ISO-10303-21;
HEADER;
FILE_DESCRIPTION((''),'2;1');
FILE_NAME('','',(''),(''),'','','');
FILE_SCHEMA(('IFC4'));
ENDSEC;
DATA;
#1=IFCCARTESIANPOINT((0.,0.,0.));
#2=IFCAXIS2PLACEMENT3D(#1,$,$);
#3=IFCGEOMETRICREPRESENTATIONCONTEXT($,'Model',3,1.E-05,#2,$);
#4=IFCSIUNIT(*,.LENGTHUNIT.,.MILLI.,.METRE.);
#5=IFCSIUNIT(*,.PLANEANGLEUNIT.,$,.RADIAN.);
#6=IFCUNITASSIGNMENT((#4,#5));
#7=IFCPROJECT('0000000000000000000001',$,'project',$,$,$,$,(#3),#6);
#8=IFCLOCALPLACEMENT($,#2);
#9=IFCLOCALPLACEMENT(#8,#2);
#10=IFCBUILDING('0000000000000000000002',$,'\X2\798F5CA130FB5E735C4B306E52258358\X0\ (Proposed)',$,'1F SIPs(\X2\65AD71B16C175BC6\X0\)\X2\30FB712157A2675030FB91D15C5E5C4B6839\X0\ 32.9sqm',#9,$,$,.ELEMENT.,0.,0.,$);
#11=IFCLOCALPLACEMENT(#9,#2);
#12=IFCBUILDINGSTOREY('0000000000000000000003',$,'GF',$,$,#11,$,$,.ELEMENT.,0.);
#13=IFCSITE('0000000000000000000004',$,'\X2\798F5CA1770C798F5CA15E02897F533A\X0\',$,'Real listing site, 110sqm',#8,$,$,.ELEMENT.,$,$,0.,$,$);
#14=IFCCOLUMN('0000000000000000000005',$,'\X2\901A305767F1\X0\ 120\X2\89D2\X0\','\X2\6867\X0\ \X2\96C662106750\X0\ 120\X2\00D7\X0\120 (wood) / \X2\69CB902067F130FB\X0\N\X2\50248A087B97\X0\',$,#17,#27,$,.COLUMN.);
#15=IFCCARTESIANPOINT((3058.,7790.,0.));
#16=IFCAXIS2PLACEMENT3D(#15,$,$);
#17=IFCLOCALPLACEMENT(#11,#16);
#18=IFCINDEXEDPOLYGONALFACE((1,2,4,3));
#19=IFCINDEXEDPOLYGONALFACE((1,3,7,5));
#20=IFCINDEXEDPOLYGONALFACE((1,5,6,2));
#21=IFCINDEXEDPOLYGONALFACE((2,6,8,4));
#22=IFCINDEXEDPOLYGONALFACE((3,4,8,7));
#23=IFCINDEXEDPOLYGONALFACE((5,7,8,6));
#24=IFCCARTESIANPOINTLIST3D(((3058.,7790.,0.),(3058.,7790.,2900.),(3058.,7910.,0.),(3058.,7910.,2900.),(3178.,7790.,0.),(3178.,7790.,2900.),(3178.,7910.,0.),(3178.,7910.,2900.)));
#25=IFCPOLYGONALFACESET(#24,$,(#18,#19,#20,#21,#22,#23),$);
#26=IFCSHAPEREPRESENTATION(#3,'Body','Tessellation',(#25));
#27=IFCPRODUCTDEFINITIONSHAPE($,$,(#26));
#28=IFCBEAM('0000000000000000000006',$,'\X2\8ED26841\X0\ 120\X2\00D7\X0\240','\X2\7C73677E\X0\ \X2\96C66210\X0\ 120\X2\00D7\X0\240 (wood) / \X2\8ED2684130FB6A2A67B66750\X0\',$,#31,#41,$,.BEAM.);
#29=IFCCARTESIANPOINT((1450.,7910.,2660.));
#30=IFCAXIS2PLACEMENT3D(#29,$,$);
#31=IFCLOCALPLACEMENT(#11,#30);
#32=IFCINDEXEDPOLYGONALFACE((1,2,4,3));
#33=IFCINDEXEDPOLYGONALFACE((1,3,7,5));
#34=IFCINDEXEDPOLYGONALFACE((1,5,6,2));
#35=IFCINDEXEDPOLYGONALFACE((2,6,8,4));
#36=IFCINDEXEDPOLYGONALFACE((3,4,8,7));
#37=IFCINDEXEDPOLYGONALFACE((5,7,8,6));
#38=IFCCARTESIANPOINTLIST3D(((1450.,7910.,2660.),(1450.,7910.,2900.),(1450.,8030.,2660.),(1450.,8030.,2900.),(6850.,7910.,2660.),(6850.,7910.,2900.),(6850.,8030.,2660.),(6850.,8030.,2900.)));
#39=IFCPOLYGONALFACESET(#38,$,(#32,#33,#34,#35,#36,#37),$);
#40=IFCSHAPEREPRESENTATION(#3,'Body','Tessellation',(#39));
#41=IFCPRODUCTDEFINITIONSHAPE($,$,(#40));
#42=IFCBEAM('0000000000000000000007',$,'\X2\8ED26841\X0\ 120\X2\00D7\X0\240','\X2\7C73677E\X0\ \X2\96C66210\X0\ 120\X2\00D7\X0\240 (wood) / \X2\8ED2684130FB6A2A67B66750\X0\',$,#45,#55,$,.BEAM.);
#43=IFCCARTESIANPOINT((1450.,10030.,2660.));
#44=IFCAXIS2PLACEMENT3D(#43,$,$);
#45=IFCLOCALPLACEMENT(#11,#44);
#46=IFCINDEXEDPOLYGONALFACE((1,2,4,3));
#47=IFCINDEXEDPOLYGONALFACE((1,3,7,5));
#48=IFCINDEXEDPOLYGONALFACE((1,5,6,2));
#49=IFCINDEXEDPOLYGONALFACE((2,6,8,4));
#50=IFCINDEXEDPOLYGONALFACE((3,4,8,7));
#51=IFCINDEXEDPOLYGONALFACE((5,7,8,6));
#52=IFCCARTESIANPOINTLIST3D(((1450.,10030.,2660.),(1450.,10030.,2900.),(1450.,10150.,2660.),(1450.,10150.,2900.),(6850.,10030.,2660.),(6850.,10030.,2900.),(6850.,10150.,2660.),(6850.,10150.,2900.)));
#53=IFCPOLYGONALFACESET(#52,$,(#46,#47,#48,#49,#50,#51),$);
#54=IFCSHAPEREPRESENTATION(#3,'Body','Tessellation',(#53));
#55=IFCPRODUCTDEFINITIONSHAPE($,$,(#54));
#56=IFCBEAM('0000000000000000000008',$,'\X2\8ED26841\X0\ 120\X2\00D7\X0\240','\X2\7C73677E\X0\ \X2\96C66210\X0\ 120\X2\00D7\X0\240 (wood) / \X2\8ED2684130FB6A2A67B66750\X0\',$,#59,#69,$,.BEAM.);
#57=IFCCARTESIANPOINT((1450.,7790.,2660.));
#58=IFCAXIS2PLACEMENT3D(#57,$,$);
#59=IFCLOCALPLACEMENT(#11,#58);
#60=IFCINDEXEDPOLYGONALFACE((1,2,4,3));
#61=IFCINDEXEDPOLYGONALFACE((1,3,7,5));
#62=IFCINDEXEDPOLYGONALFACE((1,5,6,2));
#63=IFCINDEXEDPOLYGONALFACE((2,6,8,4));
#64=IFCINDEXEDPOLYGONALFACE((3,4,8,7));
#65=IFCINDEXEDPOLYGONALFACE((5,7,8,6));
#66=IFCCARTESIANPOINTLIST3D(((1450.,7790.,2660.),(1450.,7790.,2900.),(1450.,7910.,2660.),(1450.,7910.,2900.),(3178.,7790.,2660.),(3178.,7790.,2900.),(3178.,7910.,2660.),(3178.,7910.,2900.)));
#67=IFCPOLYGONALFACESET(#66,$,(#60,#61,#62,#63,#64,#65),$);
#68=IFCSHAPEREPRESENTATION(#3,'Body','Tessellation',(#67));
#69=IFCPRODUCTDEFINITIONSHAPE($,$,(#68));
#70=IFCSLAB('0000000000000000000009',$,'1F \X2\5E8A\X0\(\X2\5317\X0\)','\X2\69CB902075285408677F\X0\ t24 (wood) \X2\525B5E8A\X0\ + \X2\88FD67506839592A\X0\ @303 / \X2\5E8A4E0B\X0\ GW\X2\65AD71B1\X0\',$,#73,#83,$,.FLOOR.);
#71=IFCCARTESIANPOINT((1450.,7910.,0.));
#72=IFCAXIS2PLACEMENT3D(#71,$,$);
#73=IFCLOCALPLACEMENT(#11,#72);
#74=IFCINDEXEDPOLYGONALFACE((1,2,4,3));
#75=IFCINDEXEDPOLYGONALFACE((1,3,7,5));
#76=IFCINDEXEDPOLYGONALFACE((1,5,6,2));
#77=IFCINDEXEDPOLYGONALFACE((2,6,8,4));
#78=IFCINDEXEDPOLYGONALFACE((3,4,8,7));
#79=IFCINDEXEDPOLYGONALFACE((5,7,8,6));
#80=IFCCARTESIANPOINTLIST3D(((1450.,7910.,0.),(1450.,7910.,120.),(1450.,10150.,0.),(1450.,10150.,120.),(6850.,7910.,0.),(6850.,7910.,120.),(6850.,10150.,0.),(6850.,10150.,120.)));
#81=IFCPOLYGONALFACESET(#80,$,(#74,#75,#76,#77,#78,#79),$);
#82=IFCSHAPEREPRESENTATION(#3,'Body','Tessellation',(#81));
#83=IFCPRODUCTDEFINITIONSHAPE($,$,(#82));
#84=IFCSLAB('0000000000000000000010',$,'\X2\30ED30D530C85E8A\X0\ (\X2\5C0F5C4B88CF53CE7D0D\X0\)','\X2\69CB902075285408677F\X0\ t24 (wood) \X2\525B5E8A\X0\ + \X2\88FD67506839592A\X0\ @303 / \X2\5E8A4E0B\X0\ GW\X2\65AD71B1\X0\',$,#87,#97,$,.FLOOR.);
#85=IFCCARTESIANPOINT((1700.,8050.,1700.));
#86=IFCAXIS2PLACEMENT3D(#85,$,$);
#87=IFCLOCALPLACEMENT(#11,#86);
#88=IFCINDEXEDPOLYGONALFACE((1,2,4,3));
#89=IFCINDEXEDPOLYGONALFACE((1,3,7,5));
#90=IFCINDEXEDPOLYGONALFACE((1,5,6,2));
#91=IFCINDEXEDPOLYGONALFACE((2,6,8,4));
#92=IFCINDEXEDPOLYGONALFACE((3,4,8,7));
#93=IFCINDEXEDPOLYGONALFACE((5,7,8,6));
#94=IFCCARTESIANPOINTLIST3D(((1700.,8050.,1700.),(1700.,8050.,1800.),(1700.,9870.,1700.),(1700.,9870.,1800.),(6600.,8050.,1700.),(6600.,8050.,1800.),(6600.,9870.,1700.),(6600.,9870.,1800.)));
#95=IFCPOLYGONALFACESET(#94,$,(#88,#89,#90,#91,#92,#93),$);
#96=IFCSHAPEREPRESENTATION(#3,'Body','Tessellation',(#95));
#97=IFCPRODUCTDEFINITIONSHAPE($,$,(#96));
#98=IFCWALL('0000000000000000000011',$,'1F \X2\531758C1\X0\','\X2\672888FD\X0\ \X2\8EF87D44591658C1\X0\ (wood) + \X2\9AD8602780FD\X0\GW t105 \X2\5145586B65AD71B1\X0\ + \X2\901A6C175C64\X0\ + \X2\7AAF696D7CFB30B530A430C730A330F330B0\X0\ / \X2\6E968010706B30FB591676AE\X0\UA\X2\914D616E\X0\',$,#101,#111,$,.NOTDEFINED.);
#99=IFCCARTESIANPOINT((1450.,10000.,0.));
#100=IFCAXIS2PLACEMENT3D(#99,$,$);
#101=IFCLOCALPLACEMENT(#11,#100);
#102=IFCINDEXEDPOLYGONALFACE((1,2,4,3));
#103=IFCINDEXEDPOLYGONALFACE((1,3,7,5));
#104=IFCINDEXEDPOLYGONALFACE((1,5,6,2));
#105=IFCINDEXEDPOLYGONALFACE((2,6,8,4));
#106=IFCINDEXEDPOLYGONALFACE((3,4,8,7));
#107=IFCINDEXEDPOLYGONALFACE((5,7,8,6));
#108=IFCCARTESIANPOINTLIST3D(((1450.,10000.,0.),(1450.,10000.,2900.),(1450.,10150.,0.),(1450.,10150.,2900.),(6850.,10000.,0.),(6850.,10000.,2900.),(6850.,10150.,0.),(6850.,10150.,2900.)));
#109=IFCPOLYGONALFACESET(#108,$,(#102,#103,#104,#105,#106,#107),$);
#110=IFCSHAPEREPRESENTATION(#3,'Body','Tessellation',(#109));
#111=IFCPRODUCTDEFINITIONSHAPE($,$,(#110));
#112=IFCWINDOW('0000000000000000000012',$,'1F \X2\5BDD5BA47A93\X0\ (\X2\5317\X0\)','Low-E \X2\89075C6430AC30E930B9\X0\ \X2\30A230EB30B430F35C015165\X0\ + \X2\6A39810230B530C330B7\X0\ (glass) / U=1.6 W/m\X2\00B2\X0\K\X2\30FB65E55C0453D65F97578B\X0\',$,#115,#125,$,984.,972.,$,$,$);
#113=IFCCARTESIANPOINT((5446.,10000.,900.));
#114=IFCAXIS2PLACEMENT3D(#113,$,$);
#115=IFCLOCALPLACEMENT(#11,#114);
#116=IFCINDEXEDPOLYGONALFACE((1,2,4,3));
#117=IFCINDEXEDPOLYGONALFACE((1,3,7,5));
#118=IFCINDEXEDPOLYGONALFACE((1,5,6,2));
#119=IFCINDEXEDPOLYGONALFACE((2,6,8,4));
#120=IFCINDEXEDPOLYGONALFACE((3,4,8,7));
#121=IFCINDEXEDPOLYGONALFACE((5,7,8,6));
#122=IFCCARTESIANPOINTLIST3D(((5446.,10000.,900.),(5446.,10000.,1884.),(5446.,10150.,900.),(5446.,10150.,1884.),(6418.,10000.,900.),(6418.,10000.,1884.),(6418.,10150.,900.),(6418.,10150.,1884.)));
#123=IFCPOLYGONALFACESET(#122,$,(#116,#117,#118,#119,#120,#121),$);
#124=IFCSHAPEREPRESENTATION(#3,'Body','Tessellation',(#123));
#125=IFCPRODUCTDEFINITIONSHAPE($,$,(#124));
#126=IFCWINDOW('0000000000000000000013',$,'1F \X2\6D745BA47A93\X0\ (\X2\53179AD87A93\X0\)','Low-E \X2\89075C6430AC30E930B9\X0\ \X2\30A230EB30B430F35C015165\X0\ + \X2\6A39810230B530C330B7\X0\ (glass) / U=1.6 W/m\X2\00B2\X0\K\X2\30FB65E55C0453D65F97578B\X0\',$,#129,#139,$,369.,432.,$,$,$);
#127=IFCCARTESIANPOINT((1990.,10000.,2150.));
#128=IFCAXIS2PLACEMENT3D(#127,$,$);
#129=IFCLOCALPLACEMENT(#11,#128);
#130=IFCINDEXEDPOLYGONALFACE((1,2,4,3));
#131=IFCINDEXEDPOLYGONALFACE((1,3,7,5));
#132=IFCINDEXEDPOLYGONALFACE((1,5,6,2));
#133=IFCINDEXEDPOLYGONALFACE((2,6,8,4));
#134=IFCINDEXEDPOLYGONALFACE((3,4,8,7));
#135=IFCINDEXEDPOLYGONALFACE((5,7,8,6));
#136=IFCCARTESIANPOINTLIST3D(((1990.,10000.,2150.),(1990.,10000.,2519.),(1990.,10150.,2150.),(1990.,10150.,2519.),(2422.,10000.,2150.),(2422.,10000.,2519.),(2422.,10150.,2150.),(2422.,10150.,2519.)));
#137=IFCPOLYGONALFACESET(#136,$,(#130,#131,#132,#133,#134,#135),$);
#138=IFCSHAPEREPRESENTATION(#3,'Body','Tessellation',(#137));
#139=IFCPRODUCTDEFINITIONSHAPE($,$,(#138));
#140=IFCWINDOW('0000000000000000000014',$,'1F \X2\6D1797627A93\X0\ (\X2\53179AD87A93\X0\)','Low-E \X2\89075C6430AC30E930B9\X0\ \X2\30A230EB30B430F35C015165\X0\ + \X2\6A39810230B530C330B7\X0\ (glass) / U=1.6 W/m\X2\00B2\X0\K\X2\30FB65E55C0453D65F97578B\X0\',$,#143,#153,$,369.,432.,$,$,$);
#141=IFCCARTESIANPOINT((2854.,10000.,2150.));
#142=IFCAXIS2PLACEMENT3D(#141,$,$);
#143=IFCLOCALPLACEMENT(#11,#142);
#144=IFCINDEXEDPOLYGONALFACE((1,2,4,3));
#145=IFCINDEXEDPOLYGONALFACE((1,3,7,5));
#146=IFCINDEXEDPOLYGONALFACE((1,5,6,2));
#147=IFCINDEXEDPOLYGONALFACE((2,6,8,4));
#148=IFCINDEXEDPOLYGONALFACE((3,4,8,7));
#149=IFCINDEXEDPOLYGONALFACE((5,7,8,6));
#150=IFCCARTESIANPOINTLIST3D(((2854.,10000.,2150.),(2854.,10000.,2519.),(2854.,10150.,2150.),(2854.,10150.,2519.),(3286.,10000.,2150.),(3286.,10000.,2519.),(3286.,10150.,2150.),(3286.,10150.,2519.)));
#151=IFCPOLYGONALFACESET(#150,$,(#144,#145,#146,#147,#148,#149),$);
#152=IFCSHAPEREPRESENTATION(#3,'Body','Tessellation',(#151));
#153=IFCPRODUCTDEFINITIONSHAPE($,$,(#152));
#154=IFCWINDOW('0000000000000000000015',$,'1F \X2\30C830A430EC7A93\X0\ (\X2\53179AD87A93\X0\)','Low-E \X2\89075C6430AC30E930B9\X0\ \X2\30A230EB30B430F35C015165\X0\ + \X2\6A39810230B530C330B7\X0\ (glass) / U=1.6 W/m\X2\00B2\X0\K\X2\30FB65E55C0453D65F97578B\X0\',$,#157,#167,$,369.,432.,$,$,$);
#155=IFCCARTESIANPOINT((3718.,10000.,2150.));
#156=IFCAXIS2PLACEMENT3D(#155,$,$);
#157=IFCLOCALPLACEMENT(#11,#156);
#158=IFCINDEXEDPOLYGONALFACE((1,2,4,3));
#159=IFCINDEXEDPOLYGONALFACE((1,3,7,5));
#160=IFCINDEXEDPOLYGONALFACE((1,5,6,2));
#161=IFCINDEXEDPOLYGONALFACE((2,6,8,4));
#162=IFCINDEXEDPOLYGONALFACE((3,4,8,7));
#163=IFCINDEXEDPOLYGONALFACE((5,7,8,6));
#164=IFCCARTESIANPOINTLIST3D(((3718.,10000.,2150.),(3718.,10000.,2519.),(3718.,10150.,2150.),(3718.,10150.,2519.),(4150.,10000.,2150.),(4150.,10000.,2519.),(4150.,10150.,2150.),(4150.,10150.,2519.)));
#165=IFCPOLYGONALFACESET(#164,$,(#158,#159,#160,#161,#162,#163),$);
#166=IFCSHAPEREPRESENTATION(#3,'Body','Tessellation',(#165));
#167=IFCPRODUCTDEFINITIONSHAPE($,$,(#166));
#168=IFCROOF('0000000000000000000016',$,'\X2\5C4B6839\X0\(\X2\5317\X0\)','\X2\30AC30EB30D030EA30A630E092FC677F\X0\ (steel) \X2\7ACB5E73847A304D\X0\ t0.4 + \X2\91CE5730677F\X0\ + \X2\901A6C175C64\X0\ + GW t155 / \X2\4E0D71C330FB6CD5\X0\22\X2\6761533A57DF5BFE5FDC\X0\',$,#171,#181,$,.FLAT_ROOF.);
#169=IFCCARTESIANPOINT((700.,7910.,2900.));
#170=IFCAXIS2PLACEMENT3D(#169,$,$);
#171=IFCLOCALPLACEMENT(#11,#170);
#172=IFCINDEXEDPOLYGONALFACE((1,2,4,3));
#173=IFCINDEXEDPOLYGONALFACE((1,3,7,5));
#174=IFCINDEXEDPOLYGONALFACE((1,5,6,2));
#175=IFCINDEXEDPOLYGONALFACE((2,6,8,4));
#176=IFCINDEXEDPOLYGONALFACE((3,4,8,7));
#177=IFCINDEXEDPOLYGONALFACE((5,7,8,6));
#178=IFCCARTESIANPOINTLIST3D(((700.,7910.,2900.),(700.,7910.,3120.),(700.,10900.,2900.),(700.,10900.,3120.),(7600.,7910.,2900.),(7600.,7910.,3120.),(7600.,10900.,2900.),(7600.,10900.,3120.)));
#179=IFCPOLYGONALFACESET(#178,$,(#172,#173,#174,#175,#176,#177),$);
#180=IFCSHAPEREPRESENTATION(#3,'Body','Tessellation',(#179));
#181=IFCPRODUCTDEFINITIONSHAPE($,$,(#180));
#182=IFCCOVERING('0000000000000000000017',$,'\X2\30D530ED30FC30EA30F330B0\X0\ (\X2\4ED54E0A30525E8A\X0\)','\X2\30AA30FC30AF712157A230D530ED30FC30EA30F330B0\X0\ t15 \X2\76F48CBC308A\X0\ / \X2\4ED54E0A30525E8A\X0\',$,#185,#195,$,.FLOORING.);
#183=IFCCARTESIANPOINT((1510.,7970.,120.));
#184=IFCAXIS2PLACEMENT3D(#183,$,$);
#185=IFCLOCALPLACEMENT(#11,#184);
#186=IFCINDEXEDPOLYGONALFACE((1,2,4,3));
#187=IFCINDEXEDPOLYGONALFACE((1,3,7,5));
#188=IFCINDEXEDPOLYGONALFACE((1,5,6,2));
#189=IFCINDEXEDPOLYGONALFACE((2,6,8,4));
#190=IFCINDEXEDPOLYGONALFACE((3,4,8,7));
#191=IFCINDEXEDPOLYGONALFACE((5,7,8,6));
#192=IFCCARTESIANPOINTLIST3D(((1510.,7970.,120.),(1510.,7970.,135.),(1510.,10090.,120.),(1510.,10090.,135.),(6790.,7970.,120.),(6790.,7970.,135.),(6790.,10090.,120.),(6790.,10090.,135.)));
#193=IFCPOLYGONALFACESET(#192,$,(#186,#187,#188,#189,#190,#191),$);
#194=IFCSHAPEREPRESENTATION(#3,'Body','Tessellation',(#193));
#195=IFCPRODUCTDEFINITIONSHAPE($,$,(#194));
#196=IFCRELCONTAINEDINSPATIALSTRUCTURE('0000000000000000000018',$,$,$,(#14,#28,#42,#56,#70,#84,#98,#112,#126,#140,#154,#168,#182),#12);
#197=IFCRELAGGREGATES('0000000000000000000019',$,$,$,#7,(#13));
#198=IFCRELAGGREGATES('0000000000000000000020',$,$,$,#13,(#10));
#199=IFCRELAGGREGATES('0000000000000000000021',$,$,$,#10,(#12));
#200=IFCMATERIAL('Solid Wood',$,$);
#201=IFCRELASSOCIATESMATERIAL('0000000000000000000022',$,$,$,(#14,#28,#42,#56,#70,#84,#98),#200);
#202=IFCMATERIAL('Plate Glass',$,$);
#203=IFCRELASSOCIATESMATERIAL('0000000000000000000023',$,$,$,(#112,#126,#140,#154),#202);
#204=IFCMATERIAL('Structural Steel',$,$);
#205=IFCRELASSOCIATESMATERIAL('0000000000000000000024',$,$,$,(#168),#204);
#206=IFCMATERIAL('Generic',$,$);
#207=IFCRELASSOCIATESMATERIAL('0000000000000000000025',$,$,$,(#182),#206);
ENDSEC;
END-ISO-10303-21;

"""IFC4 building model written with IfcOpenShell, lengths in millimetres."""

from ifc_helpers import new_model, si_unit, frame, frame_2d, origin, place, context, project, spatial, rectangle, extrude, material, element, fill, save


model = new_model("IFC4")

# Units and contexts
model_context = context("Model", 3, precision=1e-05, world=origin())
ifc_project = project(units=[si_unit("LENGTHUNIT", "METRE", prefix="MILLI"), si_unit("PLANEANGLEUNIT", "RADIAN")], contexts=[model_context])

# Site, building, storey
site_placement = place(None, origin())
site = spatial("IfcSite", under=ifc_project, at=site_placement, Name="福岡県福岡市西区", ObjectType="Real listing site, 110sqm", CompositionType="ELEMENT", RefElevation=0.0)
building_placement = place(site_placement, origin())
building = spatial("IfcBuilding", under=site, at=building_placement, Name="福岡・平屋の別荘 (Proposed)", ObjectType="1F SIPs(断熱気密)・無垢材・金属屋根 32.9sqm", CompositionType="ELEMENT", ElevationOfRefHeight=0.0, ElevationOfTerrain=0.0)
storey_placement = place(building_placement, origin())
storey = spatial("IfcBuildingStorey", under=building, at=storey_placement, Name="GF", CompositionType="ELEMENT", Elevation=0.0)

# Column
ifc_material_1 = material(Name="Solid Wood")
column_1_placement = place(storey_placement, frame((3058.0, 7790.0, 0.0)))
element("IfcColumn", 1, at=column_1_placement, inside=storey, material=ifc_material_1, Name="通し柱 120角", Description="桧 集成材 120×120 (wood) / 構造柱・N値計算", PredefinedType="COLUMN", context=model_context, shape_type="SweptSolid", body=[
    extrude(rectangle(XDim=120.0, YDim=120.0, at=frame_2d((60.0, 60.0))), frame((3058.0, 7790.0, 0.0)), (0.0, 0.0, 1.0), 2900.0),
])

# Beams
beam_1_placement = place(storey_placement, frame((1450.0, 7910.0, 2660.0)))
element("IfcBeam", 2, at=beam_1_placement, inside=storey, material=ifc_material_1, Name="軒桁 120×240", Description="米松 集成 120×240 (wood) / 軒桁・横架材", PredefinedType="BEAM", context=model_context, shape_type="SweptSolid", body=[
    extrude(rectangle(XDim=5400.0, YDim=120.0, at=frame_2d((2700.0, 60.0))), frame((1450.0, 7910.0, 2660.0)), (0.0, 0.0, 1.0), 240.0),
])
beam_2_placement = place(storey_placement, frame((1450.0, 10030.0, 2660.0)))
element("IfcBeam", 3, at=beam_2_placement, inside=storey, material=ifc_material_1, Name="軒桁 120×240", Description="米松 集成 120×240 (wood) / 軒桁・横架材", PredefinedType="BEAM", context=model_context, shape_type="SweptSolid", body=[
    extrude(rectangle(XDim=5400.0, YDim=120.0, at=frame_2d((2700.0, 60.0))), frame((1450.0, 10030.0, 2660.0)), (0.0, 0.0, 1.0), 240.0),
])
beam_3_placement = place(storey_placement, frame((1450.0, 7790.0, 2660.0)))
element("IfcBeam", 4, at=beam_3_placement, inside=storey, material=ifc_material_1, Name="軒桁 120×240", Description="米松 集成 120×240 (wood) / 軒桁・横架材", PredefinedType="BEAM", context=model_context, shape_type="SweptSolid", body=[
    extrude(rectangle(XDim=1728.0, YDim=120.0, at=frame_2d((864.0, 60.0))), frame((1450.0, 7790.0, 2660.0)), (0.0, 0.0, 1.0), 240.0),
])

# Slabs
slab_1_placement = place(storey_placement, frame((1450.0, 7910.0, 0.0)))
element("IfcSlab", 5, at=slab_1_placement, inside=storey, material=ifc_material_1, Name="1F 床(北)", Description="構造用合板 t24 (wood) 剛床 + 製材根太 @303 / 床下 GW断熱", PredefinedType="FLOOR", context=model_context, shape_type="SweptSolid", body=[
    extrude(rectangle(XDim=5400.0, YDim=2240.0, at=frame_2d((2700.0, 1120.0))), frame((1450.0, 7910.0, 0.0)), (0.0, 0.0, 1.0), 120.0),
])
slab_2_placement = place(storey_placement, frame((1700.0, 8050.0, 1700.0)))
element("IfcSlab", 6, at=slab_2_placement, inside=storey, material=ifc_material_1, Name="ロフト床 (小屋裏収納)", Description="構造用合板 t24 (wood) 剛床 + 製材根太 @303 / 床下 GW断熱", PredefinedType="FLOOR", context=model_context, shape_type="SweptSolid", body=[
    extrude(rectangle(XDim=4900.0, YDim=1820.0, at=frame_2d((2450.0, 910.0))), frame((1700.0, 8050.0, 1700.0)), (0.0, 0.0, 1.0), 100.0),
])

# Wall, openings, windows
wall_1_placement = place(storey_placement, frame((1450.0, 10000.0, 0.0)))
wall_1 = element("IfcWall", 7, at=wall_1_placement, inside=storey, material=ifc_material_1, Name="1F 北壁", Description="木製 軸組外壁 (wood) + 高性能GW t105 充填断熱 + 通気層 + 窯業系サイディング / 準耐火・外皮UA配慮", PredefinedType="NOTDEFINED", context=model_context, shape_type="SweptSolid", body=[
    extrude(rectangle(XDim=5400.0, YDim=150.0, at=frame_2d((2700.0, 75.0))), frame((1450.0, 10000.0, 0.0)), (0.0, 0.0, 1.0), 2900.0),
])
opening_1_placement = place(storey_placement, frame((5446.0, 10000.0, 900.0)))
opening_1 = element("IfcOpeningElement", 8, at=opening_1_placement, cuts=wall_1, PredefinedType="NOTDEFINED", context=model_context, shape_type="SweptSolid", body=[
    extrude(rectangle(XDim=972.0, YDim=150.0, at=frame_2d((486.0, 75.0))), frame((5446.0, 10000.0, 900.0)), (0.0, 0.0, 1.0), 984.0),
])
opening_2_placement = place(storey_placement, frame((1990.0, 10000.0, 2150.0)))
opening_2 = element("IfcOpeningElement", 9, at=opening_2_placement, cuts=wall_1, PredefinedType="NOTDEFINED", context=model_context, shape_type="SweptSolid", body=[
    extrude(rectangle(XDim=432.0, YDim=150.0, at=frame_2d((216.0, 75.0))), frame((1990.0, 10000.0, 2150.0)), (0.0, 0.0, 1.0), 369.0),
])
opening_3_placement = place(storey_placement, frame((2854.0, 10000.0, 2150.0)))
opening_3 = element("IfcOpeningElement", 10, at=opening_3_placement, cuts=wall_1, PredefinedType="NOTDEFINED", context=model_context, shape_type="SweptSolid", body=[
    extrude(rectangle(XDim=432.0, YDim=150.0, at=frame_2d((216.0, 75.0))), frame((2854.0, 10000.0, 2150.0)), (0.0, 0.0, 1.0), 369.0),
])
opening_4_placement = place(storey_placement, frame((3718.0, 10000.0, 2150.0)))
opening_4 = element("IfcOpeningElement", 11, at=opening_4_placement, cuts=wall_1, PredefinedType="NOTDEFINED", context=model_context, shape_type="SweptSolid", body=[
    extrude(rectangle(XDim=432.0, YDim=150.0, at=frame_2d((216.0, 75.0))), frame((3718.0, 10000.0, 2150.0)), (0.0, 0.0, 1.0), 369.0),
])
ifc_material_2 = material(Name="Plate Glass")
window_1_placement = place(storey_placement, frame((5446.0, 10000.0, 900.0)))
window_1 = element("IfcWindow", 12, at=window_1_placement, inside=storey, material=ifc_material_2, Name="1F 寝室窓 (北)", Description="Low-E 複層ガラス アルゴン封入 + 樹脂サッシ (glass) / U=1.6 W/m²K・日射取得型", OverallHeight=984.0, OverallWidth=972.0, context=model_context, shape_type="SweptSolid", body=[
    extrude(rectangle(XDim=972.0, YDim=150.0, at=frame_2d((486.0, 75.0))), frame((5446.0, 10000.0, 900.0)), (0.0, 0.0, 1.0), 984.0),
])
fill(opening_1, window_1)
window_2_placement = place(storey_placement, frame((1990.0, 10000.0, 2150.0)))
window_2 = element("IfcWindow", 13, at=window_2_placement, inside=storey, material=ifc_material_2, Name="1F 浴室窓 (北高窓)", Description="Low-E 複層ガラス アルゴン封入 + 樹脂サッシ (glass) / U=1.6 W/m²K・日射取得型", OverallHeight=369.0, OverallWidth=432.0, context=model_context, shape_type="SweptSolid", body=[
    extrude(rectangle(XDim=432.0, YDim=150.0, at=frame_2d((216.0, 75.0))), frame((1990.0, 10000.0, 2150.0)), (0.0, 0.0, 1.0), 369.0),
])
fill(opening_2, window_2)
window_3_placement = place(storey_placement, frame((2854.0, 10000.0, 2150.0)))
window_3 = element("IfcWindow", 14, at=window_3_placement, inside=storey, material=ifc_material_2, Name="1F 洗面窓 (北高窓)", Description="Low-E 複層ガラス アルゴン封入 + 樹脂サッシ (glass) / U=1.6 W/m²K・日射取得型", OverallHeight=369.0, OverallWidth=432.0, context=model_context, shape_type="SweptSolid", body=[
    extrude(rectangle(XDim=432.0, YDim=150.0, at=frame_2d((216.0, 75.0))), frame((2854.0, 10000.0, 2150.0)), (0.0, 0.0, 1.0), 369.0),
])
fill(opening_3, window_3)
window_4_placement = place(storey_placement, frame((3718.0, 10000.0, 2150.0)))
window_4 = element("IfcWindow", 15, at=window_4_placement, inside=storey, material=ifc_material_2, Name="1F トイレ窓 (北高窓)", Description="Low-E 複層ガラス アルゴン封入 + 樹脂サッシ (glass) / U=1.6 W/m²K・日射取得型", OverallHeight=369.0, OverallWidth=432.0, context=model_context, shape_type="SweptSolid", body=[
    extrude(rectangle(XDim=432.0, YDim=150.0, at=frame_2d((216.0, 75.0))), frame((3718.0, 10000.0, 2150.0)), (0.0, 0.0, 1.0), 369.0),
])
fill(opening_4, window_4)

# Roof
ifc_material_3 = material(Name="Structural Steel")
roof_placement = place(storey_placement, frame((700.0, 7910.0, 2900.0)))
element("IfcRoof", 16, at=roof_placement, inside=storey, material=ifc_material_3, Name="屋根(北)", Description="ガルバリウム鋼板 (steel) 立平葺き t0.4 + 野地板 + 通気層 + GW t155 / 不燃・法22条区域対応", PredefinedType="FLAT_ROOF", context=model_context, shape_type="SweptSolid", body=[
    extrude(rectangle(XDim=6900.0, YDim=2990.0, at=frame_2d((3450.0, 1495.0))), frame((700.0, 7910.0, 2900.0)), (0.0, 0.0, 1.0), 220.0),
])

# Covering
ifc_material_4 = material(Name="Generic")
covering_1_placement = place(storey_placement, frame((1510.0, 7970.0, 120.0)))
element("IfcCovering", 17, at=covering_1_placement, inside=storey, material=ifc_material_4, Name="フローリング (仕上げ床)", Description="オーク無垢フローリング t15 直貼り / 仕上げ床", PredefinedType="FLOORING", context=model_context, shape_type="SweptSolid", body=[
    extrude(rectangle(XDim=5280.0, YDim=2120.0, at=frame_2d((2640.0, 1060.0))), frame((1510.0, 7970.0, 120.0)), (0.0, 0.0, 1.0), 15.0),
])

save(model, "model.ifc")
